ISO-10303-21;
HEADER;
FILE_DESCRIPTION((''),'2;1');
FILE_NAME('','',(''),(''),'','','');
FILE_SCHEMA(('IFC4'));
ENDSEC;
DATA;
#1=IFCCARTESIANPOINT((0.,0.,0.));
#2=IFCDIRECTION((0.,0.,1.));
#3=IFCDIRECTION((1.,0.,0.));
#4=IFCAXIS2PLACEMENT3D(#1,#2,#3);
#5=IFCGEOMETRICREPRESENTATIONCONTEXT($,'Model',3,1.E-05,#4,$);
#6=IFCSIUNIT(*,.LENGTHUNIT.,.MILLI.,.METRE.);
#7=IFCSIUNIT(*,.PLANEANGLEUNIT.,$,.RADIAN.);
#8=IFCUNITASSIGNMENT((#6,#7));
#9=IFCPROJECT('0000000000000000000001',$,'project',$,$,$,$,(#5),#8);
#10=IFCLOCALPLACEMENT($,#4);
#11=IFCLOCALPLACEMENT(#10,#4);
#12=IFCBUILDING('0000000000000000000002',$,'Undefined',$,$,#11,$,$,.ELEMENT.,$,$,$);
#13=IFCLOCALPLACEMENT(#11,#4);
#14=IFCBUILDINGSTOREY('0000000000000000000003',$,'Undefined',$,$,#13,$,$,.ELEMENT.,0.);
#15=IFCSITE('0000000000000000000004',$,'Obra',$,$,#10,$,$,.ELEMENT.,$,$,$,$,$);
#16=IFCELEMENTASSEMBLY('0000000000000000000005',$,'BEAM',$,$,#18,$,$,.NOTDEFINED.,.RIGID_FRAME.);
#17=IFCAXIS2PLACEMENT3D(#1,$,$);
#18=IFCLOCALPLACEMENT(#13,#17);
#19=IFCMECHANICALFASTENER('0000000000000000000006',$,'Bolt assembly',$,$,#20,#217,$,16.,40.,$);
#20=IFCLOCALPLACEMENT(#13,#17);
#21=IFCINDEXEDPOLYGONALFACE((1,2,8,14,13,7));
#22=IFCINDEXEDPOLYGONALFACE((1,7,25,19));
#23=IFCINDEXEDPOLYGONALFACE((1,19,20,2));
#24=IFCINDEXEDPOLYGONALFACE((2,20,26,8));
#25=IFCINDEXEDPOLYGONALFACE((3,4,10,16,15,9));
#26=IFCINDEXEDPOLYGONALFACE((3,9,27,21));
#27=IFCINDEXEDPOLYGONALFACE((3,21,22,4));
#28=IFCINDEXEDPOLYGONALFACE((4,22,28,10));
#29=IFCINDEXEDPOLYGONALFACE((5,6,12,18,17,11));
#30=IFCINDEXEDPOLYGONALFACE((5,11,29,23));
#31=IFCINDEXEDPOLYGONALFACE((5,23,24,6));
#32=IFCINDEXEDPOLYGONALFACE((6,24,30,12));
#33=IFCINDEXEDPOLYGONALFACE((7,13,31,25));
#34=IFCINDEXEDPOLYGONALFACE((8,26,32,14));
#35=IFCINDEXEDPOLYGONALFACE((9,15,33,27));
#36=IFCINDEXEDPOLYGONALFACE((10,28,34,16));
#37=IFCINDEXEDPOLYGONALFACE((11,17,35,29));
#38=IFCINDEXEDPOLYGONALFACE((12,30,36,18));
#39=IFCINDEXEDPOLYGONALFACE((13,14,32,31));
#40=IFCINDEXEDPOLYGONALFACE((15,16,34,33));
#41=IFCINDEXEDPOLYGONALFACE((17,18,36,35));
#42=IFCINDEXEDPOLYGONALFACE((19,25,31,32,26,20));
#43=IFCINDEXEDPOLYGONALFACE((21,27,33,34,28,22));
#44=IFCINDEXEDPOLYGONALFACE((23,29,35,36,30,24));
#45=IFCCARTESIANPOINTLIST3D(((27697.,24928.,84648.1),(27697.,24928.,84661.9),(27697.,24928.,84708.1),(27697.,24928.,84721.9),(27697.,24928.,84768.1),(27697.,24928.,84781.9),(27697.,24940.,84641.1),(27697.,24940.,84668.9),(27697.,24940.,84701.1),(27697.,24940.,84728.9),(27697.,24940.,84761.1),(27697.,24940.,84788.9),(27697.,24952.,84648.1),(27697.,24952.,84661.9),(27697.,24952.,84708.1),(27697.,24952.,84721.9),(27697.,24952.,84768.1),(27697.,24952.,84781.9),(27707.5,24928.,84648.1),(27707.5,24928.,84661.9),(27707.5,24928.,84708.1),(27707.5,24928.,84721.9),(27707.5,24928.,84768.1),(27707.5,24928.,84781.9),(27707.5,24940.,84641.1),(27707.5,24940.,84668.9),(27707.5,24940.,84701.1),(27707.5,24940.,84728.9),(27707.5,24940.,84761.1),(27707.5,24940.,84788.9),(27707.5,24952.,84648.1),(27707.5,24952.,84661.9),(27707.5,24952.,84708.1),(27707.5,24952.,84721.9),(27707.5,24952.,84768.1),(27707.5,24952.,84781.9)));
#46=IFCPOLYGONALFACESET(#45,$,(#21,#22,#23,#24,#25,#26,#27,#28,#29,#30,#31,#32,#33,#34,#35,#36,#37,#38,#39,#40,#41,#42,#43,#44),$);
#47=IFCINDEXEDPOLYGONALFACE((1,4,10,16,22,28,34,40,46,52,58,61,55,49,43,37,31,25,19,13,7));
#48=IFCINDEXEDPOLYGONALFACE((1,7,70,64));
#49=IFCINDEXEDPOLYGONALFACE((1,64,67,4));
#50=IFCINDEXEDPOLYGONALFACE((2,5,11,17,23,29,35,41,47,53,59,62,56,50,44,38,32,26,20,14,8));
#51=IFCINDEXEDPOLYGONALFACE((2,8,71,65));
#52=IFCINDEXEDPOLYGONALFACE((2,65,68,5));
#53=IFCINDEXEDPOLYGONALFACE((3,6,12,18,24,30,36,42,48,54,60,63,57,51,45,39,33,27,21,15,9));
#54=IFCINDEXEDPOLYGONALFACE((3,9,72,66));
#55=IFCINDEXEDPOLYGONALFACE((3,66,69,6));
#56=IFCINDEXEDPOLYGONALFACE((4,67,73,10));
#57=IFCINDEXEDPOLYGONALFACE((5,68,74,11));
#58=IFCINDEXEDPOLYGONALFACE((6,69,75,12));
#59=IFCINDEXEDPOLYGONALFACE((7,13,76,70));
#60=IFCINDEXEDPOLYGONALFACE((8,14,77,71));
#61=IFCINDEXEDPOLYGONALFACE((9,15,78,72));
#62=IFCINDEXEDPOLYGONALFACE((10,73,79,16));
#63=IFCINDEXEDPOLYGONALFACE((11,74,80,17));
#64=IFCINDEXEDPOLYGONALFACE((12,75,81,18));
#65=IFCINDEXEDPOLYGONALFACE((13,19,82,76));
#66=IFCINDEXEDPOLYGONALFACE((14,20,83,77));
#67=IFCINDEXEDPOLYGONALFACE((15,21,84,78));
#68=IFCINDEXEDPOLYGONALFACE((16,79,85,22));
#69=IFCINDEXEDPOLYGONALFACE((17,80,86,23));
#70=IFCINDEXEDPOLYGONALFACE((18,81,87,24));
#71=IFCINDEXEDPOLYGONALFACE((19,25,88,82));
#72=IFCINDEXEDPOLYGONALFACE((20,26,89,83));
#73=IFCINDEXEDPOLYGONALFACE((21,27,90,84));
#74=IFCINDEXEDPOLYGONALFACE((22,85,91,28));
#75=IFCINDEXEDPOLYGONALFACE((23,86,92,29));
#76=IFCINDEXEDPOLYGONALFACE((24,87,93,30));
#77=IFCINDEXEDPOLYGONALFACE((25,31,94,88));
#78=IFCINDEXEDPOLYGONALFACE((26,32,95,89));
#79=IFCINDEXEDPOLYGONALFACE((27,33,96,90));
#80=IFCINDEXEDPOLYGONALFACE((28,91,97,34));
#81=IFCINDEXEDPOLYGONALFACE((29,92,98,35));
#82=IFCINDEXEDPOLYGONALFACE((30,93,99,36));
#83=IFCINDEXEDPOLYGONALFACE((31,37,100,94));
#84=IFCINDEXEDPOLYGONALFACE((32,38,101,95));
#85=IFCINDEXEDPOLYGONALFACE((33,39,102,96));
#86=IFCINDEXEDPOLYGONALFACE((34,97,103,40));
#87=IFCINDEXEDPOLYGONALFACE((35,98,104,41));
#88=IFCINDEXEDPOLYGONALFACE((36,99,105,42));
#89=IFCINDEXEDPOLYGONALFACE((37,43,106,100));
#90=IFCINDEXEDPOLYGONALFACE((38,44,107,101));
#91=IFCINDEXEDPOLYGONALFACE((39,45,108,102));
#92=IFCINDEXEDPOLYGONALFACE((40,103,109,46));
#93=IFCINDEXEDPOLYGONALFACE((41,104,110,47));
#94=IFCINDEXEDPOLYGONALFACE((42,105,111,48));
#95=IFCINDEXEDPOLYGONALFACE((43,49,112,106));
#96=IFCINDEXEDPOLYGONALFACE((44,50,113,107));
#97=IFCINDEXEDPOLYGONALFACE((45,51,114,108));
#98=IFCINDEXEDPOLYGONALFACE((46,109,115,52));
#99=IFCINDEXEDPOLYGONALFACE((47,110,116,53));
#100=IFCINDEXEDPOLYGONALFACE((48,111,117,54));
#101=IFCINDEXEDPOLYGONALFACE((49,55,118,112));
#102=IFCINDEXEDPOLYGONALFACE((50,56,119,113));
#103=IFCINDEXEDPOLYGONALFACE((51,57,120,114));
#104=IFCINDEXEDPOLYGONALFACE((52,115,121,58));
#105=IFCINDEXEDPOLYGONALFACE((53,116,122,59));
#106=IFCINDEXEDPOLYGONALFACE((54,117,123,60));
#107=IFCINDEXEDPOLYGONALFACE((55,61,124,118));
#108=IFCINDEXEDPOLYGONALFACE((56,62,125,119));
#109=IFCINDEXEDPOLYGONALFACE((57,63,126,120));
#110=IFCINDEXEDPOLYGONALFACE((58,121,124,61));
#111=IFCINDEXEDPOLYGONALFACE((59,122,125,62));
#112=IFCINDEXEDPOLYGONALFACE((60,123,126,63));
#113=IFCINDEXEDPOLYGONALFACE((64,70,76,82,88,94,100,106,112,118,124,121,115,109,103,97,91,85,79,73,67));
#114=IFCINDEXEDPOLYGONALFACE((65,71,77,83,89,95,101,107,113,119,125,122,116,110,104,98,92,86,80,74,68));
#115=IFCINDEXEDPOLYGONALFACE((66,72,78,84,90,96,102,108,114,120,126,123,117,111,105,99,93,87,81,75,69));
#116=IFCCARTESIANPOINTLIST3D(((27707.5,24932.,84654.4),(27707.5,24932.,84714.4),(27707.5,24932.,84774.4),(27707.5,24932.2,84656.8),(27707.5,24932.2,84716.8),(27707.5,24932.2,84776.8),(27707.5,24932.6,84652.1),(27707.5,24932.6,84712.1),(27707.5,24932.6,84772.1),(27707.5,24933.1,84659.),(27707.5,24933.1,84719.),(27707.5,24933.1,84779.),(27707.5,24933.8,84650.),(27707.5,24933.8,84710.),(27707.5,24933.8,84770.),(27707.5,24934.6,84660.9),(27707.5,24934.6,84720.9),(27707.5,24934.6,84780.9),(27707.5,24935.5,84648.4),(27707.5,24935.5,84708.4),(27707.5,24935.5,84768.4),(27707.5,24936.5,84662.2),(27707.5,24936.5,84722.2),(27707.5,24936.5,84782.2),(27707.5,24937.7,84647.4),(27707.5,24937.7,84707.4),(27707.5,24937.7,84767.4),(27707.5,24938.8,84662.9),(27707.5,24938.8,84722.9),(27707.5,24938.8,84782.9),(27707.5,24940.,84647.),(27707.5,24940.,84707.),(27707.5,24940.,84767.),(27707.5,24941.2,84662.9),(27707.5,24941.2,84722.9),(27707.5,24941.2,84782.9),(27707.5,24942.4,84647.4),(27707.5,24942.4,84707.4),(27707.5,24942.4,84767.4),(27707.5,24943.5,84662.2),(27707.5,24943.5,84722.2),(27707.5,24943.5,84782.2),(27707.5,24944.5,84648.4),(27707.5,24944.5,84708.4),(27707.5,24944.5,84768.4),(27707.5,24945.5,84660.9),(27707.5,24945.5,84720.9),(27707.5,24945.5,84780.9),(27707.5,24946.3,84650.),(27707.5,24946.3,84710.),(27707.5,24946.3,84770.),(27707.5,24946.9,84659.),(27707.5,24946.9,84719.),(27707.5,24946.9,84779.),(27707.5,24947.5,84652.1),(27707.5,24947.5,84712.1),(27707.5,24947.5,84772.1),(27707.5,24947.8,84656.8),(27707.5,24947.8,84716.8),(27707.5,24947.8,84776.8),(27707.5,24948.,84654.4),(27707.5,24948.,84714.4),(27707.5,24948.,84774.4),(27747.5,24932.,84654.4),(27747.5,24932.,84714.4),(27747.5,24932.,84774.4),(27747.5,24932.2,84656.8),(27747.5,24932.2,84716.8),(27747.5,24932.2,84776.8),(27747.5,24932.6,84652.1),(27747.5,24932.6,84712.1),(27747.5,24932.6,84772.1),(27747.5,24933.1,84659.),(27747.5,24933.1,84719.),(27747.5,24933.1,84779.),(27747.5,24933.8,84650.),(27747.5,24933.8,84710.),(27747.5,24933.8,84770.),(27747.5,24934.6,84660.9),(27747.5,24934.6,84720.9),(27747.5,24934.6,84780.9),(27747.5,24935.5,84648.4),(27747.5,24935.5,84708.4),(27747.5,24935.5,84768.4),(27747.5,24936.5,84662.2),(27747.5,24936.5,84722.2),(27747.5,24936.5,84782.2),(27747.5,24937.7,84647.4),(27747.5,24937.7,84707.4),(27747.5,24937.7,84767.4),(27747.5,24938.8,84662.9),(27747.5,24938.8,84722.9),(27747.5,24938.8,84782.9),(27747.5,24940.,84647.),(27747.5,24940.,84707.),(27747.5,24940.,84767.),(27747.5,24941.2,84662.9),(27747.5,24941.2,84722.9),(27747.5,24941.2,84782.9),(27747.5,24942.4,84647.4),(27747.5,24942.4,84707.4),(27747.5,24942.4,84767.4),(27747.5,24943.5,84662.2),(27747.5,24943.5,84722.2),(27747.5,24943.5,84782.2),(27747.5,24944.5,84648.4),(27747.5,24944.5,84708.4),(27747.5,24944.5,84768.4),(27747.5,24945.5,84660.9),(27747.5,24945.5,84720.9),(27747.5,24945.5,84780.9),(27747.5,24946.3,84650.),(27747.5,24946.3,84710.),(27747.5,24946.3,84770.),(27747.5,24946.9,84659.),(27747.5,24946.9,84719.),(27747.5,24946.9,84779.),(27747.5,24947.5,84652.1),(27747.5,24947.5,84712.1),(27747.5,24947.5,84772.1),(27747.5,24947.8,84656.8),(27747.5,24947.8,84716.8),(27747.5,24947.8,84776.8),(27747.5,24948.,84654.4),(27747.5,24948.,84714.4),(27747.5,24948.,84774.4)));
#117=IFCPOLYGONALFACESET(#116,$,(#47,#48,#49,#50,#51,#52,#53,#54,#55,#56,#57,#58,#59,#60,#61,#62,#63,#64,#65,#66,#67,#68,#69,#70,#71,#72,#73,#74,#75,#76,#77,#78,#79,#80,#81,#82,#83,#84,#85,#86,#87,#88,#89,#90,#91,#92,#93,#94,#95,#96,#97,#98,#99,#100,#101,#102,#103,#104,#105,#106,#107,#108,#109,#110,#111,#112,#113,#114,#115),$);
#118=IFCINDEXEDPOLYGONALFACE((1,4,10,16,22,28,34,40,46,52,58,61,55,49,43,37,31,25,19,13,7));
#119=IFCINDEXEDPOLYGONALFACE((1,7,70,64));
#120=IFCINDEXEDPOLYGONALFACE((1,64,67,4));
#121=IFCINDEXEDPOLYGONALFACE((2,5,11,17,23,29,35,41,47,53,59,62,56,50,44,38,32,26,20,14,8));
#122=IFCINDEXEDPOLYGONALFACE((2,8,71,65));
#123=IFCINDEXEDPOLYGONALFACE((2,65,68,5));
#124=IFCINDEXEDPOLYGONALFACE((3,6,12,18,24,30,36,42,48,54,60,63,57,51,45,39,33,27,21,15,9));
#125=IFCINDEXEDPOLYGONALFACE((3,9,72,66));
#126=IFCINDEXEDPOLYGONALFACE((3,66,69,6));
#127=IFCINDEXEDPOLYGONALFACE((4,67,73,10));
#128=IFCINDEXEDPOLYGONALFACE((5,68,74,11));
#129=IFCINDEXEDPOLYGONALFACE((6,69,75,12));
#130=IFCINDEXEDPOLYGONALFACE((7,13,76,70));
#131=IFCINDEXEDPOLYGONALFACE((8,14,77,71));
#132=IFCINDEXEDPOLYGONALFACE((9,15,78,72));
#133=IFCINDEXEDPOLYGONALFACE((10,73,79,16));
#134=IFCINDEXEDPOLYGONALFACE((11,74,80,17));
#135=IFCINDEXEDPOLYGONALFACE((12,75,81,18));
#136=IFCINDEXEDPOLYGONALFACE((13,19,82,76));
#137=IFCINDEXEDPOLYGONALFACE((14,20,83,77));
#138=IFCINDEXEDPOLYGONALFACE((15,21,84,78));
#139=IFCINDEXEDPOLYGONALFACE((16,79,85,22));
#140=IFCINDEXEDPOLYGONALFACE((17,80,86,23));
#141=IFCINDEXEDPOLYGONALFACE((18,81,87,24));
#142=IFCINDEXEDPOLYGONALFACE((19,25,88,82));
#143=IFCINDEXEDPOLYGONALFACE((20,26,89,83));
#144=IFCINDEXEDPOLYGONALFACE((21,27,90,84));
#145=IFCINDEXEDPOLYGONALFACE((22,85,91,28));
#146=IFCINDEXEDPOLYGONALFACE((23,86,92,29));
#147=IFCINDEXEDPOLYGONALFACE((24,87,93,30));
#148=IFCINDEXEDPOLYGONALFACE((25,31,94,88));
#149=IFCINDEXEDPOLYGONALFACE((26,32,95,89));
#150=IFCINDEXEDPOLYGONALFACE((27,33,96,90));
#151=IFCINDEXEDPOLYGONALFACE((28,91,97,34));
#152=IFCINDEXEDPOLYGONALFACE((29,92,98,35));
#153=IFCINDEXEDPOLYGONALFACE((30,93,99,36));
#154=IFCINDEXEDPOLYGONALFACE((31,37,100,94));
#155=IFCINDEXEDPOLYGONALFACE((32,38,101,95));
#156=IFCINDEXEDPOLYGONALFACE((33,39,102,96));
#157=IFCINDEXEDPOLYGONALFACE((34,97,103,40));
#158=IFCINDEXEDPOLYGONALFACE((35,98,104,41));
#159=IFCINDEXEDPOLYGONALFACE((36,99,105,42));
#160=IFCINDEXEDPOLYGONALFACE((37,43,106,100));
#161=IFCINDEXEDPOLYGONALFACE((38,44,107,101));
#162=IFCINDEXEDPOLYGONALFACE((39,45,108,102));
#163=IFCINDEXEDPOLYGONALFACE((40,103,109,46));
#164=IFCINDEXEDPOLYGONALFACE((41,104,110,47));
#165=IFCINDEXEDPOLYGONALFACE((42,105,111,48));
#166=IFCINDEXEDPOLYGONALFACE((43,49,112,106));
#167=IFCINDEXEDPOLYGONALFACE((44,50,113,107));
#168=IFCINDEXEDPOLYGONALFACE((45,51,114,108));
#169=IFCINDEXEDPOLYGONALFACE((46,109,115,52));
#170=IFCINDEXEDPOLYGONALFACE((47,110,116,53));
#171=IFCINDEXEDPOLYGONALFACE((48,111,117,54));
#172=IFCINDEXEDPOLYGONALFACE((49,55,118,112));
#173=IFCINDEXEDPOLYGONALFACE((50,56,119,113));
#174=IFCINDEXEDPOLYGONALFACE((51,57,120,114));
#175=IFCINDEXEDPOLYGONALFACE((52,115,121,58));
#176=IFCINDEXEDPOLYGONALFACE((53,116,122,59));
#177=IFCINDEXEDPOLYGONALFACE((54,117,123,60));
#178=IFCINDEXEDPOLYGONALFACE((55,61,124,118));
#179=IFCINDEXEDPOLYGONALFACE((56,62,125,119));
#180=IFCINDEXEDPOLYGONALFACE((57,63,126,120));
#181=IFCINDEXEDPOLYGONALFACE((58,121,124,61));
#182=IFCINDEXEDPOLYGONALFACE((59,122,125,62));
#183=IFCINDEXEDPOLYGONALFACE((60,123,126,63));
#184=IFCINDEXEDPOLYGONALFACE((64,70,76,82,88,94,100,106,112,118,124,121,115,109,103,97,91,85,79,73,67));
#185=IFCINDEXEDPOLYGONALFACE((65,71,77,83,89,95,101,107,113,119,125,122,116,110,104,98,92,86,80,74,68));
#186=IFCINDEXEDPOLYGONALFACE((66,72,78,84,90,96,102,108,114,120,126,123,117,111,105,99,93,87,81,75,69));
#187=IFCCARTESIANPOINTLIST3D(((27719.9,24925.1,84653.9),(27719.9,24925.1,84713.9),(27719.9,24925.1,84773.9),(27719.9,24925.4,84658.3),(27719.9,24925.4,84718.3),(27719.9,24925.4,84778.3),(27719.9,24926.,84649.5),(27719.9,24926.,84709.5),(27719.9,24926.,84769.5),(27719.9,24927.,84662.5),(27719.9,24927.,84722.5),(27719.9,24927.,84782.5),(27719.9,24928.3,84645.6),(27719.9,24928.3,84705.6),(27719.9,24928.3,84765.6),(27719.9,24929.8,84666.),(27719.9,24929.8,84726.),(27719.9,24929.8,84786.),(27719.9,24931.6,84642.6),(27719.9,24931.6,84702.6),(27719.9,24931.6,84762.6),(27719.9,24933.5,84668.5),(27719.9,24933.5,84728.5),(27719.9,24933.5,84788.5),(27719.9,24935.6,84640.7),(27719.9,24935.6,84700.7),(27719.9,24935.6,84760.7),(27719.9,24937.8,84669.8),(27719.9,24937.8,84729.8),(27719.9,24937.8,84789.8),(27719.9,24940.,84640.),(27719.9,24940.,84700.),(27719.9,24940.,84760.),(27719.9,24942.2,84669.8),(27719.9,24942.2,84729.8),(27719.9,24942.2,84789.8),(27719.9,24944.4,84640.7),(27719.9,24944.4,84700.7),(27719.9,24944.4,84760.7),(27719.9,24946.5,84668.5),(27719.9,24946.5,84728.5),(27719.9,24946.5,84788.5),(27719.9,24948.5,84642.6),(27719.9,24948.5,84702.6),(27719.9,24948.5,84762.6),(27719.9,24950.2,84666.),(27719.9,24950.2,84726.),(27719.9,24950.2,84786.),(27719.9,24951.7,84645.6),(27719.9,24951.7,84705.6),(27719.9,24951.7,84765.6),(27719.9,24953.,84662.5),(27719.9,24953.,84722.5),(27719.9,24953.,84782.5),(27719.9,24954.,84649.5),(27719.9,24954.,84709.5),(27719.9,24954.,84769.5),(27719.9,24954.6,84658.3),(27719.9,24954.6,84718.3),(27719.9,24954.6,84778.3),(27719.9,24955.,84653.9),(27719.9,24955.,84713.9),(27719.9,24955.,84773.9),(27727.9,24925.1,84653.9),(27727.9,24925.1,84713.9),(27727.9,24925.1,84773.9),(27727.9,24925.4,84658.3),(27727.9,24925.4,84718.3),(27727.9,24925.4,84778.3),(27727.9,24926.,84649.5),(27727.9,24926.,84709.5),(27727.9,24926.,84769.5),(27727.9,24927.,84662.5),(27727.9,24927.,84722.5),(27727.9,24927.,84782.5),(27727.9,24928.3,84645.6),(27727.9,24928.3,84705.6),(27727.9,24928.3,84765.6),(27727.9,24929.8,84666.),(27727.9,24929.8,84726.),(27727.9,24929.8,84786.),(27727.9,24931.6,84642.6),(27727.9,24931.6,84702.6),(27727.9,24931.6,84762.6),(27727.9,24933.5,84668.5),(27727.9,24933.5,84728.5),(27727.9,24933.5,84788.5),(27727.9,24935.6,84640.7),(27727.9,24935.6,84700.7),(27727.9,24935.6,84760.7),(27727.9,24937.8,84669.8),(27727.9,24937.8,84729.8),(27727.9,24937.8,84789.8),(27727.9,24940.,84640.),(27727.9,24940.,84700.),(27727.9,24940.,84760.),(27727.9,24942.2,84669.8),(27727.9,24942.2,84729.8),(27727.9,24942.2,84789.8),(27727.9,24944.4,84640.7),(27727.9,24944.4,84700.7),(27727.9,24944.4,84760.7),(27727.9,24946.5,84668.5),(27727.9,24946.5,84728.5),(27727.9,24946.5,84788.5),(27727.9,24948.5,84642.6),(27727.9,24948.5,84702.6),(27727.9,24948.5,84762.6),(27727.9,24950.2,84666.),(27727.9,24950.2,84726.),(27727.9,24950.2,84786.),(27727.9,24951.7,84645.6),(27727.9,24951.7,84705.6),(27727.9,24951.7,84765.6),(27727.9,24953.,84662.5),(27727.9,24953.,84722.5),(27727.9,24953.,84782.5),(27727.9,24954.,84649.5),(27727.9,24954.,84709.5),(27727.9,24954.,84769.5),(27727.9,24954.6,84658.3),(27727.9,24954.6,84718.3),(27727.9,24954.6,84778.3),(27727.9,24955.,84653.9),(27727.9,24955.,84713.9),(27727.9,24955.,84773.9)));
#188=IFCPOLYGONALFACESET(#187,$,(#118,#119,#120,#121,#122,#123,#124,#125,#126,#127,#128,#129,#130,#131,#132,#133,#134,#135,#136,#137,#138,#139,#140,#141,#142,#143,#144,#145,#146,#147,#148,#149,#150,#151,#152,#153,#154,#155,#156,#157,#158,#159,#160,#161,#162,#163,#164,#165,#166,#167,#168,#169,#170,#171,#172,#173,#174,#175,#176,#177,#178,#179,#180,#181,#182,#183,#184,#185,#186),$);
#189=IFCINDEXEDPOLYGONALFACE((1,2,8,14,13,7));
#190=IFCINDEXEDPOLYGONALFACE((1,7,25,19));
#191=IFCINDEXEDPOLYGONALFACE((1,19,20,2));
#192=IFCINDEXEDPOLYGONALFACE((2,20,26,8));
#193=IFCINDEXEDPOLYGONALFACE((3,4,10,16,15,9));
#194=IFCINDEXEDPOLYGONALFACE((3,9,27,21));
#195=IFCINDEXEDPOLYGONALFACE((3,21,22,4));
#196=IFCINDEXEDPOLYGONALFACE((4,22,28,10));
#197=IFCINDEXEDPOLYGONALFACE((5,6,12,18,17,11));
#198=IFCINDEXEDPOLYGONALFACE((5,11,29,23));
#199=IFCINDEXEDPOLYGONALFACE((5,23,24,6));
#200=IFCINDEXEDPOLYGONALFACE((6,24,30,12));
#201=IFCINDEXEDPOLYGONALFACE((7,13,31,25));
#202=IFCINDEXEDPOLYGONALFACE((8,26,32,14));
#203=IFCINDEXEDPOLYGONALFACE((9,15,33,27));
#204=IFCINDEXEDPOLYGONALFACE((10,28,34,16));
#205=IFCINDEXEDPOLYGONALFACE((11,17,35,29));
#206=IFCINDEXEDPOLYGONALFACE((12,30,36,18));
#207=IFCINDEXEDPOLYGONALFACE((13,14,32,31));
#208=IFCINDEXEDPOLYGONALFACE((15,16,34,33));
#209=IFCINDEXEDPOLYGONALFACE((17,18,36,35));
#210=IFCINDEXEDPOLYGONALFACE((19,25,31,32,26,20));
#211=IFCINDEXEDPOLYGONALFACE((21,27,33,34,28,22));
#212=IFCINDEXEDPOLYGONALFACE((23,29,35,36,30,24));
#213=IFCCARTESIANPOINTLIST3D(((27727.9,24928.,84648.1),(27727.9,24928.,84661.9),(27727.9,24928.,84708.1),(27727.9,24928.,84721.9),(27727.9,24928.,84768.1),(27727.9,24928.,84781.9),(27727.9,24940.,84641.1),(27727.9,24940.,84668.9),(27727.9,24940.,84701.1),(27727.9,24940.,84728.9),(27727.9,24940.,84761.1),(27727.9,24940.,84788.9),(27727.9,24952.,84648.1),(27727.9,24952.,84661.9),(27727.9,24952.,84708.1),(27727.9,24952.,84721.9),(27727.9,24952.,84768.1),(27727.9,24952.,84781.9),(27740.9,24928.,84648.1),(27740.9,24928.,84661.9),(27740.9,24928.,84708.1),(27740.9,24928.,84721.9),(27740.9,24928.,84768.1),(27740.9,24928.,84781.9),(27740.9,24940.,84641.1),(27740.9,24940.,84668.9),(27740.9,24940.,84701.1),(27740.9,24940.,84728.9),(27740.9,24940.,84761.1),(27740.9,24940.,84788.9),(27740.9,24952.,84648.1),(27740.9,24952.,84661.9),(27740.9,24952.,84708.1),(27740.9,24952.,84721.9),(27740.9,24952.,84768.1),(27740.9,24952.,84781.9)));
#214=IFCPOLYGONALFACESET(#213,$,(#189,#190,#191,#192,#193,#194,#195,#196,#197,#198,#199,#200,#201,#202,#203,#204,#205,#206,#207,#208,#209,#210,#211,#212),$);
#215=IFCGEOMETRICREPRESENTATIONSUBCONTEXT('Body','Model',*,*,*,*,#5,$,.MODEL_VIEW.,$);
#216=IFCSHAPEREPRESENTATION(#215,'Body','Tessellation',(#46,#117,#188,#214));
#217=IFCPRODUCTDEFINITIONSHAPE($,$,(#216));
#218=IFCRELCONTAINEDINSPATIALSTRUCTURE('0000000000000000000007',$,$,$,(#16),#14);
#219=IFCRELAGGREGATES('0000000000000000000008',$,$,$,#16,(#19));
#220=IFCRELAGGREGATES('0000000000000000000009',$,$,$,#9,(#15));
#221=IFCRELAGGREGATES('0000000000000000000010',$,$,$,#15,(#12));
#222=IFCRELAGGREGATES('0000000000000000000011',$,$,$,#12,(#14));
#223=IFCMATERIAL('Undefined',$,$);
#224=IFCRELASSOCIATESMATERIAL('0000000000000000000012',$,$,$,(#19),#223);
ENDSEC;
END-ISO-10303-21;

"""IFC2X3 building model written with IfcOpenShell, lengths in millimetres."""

from ifc_helpers import new_model, si_unit, frame, origin_with_axes, origin_2d_with_axis, place, context, subcontext, project, spatial, polyline, circle, outline, extrude, source, transform, mapped, material, element, aggregate, save


model = new_model("IFC2X3")

# Units and contexts
model_context = context("Model", 3, precision=1e-05, world=origin_with_axes())
body_context = subcontext(model_context, "Body", "Model", "MODEL_VIEW")
ifc_project = project(units=[si_unit("LENGTHUNIT", "METRE", prefix="MILLI"), si_unit("PLANEANGLEUNIT", "RADIAN")], contexts=[model_context])

# Site, building, storey
site_placement = place(None, origin_with_axes())
site = spatial("IfcSite", under=ifc_project, at=site_placement, Name="Obra", CompositionType="ELEMENT")
building_placement = place(site_placement, origin_with_axes())
building = spatial("IfcBuilding", under=site, at=building_placement, Name="Undefined", CompositionType="ELEMENT")
storey_placement = place(building_placement, origin_with_axes())
storey = spatial("IfcBuildingStorey", under=building, at=storey_placement, Name="Undefined", CompositionType="ELEMENT", Elevation=0.0)

# Element assembly
ifc_material_1 = material(Name="Undefined")
assembly_1_placement = place(storey_placement, origin_with_axes())
assembly_1 = element("IfcElementAssembly", 1, at=assembly_1_placement, inside=storey, Name="BEAM", AssemblyPlace="NOTDEFINED", PredefinedType="RIGID_FRAME")

# Mechanical fastener
shared_shape_1 = source(origin_with_axes(), body_context, "Body", "SweptSolid", [
    extrude(outline(polyline([(13.9, 0.0), (6.9, 12.0), (-6.9, 12.0), (-13.9, 0.0), (-6.9, -12.0), (6.9, -12.0), (13.9, 0.0)])), frame((0.0, -19.7, 0.0), z_axis=(0.0, 1.0, 0.0), x_axis=(1.0, 0.0, 0.0)), (0.0, 0.0, 1.0), 10.6),
    extrude(circle(Radius=8.0, at=origin_2d_with_axis()), frame((0.0, -9.1, 0.0), z_axis=(0.0, 1.0, 0.0), x_axis=(1.0, 0.0, 0.0)), (0.0, 0.0, 1.0), 40.0),
    extrude(circle(Radius=15.0, at=origin_2d_with_axis()), frame((0.0, 3.3, 0.0), z_axis=(0.0, 1.0, 0.0), x_axis=(1.0, 0.0, 0.0)), (0.0, 0.0, 1.0), 8.0),
    extrude(outline(polyline([(13.9, 0.0), (6.9, 12.0), (-6.9, 12.0), (-13.9, 0.0), (-6.9, -12.0), (6.9, -12.0), (13.9, 0.0)])), frame((0.0, 11.3, 0.0), z_axis=(0.0, 1.0, 0.0), x_axis=(1.0, 0.0, 0.0)), (0.0, 0.0, 1.0), 13.0),
])
mechanical_fastener_1_placement = place(assembly_1_placement, frame((27716.6, 24990.0, 84835.0), z_axis=(0.000002, -1.0, 0.0), x_axis=(0.0, 0.0, -1.0)))
mechanical_fastener_1 = element("IfcMechanicalFastener", 2, at=mechanical_fastener_1_placement, material=ifc_material_1, Name="Bolt assembly", NominalDiameter=16.0, NominalLength=40.0, context=body_context, shape_type="MappedRepresentation", body=[
    mapped(shared_shape_1, transform((60.0, 0.0, 50.0))),
    mapped(shared_shape_1, transform((120.0, 0.0, 50.0))),
    mapped(shared_shape_1, transform((180.0, 0.0, 50.0))),
])
aggregate(assembly_1, [mechanical_fastener_1])

save(model, "model.ifc")
